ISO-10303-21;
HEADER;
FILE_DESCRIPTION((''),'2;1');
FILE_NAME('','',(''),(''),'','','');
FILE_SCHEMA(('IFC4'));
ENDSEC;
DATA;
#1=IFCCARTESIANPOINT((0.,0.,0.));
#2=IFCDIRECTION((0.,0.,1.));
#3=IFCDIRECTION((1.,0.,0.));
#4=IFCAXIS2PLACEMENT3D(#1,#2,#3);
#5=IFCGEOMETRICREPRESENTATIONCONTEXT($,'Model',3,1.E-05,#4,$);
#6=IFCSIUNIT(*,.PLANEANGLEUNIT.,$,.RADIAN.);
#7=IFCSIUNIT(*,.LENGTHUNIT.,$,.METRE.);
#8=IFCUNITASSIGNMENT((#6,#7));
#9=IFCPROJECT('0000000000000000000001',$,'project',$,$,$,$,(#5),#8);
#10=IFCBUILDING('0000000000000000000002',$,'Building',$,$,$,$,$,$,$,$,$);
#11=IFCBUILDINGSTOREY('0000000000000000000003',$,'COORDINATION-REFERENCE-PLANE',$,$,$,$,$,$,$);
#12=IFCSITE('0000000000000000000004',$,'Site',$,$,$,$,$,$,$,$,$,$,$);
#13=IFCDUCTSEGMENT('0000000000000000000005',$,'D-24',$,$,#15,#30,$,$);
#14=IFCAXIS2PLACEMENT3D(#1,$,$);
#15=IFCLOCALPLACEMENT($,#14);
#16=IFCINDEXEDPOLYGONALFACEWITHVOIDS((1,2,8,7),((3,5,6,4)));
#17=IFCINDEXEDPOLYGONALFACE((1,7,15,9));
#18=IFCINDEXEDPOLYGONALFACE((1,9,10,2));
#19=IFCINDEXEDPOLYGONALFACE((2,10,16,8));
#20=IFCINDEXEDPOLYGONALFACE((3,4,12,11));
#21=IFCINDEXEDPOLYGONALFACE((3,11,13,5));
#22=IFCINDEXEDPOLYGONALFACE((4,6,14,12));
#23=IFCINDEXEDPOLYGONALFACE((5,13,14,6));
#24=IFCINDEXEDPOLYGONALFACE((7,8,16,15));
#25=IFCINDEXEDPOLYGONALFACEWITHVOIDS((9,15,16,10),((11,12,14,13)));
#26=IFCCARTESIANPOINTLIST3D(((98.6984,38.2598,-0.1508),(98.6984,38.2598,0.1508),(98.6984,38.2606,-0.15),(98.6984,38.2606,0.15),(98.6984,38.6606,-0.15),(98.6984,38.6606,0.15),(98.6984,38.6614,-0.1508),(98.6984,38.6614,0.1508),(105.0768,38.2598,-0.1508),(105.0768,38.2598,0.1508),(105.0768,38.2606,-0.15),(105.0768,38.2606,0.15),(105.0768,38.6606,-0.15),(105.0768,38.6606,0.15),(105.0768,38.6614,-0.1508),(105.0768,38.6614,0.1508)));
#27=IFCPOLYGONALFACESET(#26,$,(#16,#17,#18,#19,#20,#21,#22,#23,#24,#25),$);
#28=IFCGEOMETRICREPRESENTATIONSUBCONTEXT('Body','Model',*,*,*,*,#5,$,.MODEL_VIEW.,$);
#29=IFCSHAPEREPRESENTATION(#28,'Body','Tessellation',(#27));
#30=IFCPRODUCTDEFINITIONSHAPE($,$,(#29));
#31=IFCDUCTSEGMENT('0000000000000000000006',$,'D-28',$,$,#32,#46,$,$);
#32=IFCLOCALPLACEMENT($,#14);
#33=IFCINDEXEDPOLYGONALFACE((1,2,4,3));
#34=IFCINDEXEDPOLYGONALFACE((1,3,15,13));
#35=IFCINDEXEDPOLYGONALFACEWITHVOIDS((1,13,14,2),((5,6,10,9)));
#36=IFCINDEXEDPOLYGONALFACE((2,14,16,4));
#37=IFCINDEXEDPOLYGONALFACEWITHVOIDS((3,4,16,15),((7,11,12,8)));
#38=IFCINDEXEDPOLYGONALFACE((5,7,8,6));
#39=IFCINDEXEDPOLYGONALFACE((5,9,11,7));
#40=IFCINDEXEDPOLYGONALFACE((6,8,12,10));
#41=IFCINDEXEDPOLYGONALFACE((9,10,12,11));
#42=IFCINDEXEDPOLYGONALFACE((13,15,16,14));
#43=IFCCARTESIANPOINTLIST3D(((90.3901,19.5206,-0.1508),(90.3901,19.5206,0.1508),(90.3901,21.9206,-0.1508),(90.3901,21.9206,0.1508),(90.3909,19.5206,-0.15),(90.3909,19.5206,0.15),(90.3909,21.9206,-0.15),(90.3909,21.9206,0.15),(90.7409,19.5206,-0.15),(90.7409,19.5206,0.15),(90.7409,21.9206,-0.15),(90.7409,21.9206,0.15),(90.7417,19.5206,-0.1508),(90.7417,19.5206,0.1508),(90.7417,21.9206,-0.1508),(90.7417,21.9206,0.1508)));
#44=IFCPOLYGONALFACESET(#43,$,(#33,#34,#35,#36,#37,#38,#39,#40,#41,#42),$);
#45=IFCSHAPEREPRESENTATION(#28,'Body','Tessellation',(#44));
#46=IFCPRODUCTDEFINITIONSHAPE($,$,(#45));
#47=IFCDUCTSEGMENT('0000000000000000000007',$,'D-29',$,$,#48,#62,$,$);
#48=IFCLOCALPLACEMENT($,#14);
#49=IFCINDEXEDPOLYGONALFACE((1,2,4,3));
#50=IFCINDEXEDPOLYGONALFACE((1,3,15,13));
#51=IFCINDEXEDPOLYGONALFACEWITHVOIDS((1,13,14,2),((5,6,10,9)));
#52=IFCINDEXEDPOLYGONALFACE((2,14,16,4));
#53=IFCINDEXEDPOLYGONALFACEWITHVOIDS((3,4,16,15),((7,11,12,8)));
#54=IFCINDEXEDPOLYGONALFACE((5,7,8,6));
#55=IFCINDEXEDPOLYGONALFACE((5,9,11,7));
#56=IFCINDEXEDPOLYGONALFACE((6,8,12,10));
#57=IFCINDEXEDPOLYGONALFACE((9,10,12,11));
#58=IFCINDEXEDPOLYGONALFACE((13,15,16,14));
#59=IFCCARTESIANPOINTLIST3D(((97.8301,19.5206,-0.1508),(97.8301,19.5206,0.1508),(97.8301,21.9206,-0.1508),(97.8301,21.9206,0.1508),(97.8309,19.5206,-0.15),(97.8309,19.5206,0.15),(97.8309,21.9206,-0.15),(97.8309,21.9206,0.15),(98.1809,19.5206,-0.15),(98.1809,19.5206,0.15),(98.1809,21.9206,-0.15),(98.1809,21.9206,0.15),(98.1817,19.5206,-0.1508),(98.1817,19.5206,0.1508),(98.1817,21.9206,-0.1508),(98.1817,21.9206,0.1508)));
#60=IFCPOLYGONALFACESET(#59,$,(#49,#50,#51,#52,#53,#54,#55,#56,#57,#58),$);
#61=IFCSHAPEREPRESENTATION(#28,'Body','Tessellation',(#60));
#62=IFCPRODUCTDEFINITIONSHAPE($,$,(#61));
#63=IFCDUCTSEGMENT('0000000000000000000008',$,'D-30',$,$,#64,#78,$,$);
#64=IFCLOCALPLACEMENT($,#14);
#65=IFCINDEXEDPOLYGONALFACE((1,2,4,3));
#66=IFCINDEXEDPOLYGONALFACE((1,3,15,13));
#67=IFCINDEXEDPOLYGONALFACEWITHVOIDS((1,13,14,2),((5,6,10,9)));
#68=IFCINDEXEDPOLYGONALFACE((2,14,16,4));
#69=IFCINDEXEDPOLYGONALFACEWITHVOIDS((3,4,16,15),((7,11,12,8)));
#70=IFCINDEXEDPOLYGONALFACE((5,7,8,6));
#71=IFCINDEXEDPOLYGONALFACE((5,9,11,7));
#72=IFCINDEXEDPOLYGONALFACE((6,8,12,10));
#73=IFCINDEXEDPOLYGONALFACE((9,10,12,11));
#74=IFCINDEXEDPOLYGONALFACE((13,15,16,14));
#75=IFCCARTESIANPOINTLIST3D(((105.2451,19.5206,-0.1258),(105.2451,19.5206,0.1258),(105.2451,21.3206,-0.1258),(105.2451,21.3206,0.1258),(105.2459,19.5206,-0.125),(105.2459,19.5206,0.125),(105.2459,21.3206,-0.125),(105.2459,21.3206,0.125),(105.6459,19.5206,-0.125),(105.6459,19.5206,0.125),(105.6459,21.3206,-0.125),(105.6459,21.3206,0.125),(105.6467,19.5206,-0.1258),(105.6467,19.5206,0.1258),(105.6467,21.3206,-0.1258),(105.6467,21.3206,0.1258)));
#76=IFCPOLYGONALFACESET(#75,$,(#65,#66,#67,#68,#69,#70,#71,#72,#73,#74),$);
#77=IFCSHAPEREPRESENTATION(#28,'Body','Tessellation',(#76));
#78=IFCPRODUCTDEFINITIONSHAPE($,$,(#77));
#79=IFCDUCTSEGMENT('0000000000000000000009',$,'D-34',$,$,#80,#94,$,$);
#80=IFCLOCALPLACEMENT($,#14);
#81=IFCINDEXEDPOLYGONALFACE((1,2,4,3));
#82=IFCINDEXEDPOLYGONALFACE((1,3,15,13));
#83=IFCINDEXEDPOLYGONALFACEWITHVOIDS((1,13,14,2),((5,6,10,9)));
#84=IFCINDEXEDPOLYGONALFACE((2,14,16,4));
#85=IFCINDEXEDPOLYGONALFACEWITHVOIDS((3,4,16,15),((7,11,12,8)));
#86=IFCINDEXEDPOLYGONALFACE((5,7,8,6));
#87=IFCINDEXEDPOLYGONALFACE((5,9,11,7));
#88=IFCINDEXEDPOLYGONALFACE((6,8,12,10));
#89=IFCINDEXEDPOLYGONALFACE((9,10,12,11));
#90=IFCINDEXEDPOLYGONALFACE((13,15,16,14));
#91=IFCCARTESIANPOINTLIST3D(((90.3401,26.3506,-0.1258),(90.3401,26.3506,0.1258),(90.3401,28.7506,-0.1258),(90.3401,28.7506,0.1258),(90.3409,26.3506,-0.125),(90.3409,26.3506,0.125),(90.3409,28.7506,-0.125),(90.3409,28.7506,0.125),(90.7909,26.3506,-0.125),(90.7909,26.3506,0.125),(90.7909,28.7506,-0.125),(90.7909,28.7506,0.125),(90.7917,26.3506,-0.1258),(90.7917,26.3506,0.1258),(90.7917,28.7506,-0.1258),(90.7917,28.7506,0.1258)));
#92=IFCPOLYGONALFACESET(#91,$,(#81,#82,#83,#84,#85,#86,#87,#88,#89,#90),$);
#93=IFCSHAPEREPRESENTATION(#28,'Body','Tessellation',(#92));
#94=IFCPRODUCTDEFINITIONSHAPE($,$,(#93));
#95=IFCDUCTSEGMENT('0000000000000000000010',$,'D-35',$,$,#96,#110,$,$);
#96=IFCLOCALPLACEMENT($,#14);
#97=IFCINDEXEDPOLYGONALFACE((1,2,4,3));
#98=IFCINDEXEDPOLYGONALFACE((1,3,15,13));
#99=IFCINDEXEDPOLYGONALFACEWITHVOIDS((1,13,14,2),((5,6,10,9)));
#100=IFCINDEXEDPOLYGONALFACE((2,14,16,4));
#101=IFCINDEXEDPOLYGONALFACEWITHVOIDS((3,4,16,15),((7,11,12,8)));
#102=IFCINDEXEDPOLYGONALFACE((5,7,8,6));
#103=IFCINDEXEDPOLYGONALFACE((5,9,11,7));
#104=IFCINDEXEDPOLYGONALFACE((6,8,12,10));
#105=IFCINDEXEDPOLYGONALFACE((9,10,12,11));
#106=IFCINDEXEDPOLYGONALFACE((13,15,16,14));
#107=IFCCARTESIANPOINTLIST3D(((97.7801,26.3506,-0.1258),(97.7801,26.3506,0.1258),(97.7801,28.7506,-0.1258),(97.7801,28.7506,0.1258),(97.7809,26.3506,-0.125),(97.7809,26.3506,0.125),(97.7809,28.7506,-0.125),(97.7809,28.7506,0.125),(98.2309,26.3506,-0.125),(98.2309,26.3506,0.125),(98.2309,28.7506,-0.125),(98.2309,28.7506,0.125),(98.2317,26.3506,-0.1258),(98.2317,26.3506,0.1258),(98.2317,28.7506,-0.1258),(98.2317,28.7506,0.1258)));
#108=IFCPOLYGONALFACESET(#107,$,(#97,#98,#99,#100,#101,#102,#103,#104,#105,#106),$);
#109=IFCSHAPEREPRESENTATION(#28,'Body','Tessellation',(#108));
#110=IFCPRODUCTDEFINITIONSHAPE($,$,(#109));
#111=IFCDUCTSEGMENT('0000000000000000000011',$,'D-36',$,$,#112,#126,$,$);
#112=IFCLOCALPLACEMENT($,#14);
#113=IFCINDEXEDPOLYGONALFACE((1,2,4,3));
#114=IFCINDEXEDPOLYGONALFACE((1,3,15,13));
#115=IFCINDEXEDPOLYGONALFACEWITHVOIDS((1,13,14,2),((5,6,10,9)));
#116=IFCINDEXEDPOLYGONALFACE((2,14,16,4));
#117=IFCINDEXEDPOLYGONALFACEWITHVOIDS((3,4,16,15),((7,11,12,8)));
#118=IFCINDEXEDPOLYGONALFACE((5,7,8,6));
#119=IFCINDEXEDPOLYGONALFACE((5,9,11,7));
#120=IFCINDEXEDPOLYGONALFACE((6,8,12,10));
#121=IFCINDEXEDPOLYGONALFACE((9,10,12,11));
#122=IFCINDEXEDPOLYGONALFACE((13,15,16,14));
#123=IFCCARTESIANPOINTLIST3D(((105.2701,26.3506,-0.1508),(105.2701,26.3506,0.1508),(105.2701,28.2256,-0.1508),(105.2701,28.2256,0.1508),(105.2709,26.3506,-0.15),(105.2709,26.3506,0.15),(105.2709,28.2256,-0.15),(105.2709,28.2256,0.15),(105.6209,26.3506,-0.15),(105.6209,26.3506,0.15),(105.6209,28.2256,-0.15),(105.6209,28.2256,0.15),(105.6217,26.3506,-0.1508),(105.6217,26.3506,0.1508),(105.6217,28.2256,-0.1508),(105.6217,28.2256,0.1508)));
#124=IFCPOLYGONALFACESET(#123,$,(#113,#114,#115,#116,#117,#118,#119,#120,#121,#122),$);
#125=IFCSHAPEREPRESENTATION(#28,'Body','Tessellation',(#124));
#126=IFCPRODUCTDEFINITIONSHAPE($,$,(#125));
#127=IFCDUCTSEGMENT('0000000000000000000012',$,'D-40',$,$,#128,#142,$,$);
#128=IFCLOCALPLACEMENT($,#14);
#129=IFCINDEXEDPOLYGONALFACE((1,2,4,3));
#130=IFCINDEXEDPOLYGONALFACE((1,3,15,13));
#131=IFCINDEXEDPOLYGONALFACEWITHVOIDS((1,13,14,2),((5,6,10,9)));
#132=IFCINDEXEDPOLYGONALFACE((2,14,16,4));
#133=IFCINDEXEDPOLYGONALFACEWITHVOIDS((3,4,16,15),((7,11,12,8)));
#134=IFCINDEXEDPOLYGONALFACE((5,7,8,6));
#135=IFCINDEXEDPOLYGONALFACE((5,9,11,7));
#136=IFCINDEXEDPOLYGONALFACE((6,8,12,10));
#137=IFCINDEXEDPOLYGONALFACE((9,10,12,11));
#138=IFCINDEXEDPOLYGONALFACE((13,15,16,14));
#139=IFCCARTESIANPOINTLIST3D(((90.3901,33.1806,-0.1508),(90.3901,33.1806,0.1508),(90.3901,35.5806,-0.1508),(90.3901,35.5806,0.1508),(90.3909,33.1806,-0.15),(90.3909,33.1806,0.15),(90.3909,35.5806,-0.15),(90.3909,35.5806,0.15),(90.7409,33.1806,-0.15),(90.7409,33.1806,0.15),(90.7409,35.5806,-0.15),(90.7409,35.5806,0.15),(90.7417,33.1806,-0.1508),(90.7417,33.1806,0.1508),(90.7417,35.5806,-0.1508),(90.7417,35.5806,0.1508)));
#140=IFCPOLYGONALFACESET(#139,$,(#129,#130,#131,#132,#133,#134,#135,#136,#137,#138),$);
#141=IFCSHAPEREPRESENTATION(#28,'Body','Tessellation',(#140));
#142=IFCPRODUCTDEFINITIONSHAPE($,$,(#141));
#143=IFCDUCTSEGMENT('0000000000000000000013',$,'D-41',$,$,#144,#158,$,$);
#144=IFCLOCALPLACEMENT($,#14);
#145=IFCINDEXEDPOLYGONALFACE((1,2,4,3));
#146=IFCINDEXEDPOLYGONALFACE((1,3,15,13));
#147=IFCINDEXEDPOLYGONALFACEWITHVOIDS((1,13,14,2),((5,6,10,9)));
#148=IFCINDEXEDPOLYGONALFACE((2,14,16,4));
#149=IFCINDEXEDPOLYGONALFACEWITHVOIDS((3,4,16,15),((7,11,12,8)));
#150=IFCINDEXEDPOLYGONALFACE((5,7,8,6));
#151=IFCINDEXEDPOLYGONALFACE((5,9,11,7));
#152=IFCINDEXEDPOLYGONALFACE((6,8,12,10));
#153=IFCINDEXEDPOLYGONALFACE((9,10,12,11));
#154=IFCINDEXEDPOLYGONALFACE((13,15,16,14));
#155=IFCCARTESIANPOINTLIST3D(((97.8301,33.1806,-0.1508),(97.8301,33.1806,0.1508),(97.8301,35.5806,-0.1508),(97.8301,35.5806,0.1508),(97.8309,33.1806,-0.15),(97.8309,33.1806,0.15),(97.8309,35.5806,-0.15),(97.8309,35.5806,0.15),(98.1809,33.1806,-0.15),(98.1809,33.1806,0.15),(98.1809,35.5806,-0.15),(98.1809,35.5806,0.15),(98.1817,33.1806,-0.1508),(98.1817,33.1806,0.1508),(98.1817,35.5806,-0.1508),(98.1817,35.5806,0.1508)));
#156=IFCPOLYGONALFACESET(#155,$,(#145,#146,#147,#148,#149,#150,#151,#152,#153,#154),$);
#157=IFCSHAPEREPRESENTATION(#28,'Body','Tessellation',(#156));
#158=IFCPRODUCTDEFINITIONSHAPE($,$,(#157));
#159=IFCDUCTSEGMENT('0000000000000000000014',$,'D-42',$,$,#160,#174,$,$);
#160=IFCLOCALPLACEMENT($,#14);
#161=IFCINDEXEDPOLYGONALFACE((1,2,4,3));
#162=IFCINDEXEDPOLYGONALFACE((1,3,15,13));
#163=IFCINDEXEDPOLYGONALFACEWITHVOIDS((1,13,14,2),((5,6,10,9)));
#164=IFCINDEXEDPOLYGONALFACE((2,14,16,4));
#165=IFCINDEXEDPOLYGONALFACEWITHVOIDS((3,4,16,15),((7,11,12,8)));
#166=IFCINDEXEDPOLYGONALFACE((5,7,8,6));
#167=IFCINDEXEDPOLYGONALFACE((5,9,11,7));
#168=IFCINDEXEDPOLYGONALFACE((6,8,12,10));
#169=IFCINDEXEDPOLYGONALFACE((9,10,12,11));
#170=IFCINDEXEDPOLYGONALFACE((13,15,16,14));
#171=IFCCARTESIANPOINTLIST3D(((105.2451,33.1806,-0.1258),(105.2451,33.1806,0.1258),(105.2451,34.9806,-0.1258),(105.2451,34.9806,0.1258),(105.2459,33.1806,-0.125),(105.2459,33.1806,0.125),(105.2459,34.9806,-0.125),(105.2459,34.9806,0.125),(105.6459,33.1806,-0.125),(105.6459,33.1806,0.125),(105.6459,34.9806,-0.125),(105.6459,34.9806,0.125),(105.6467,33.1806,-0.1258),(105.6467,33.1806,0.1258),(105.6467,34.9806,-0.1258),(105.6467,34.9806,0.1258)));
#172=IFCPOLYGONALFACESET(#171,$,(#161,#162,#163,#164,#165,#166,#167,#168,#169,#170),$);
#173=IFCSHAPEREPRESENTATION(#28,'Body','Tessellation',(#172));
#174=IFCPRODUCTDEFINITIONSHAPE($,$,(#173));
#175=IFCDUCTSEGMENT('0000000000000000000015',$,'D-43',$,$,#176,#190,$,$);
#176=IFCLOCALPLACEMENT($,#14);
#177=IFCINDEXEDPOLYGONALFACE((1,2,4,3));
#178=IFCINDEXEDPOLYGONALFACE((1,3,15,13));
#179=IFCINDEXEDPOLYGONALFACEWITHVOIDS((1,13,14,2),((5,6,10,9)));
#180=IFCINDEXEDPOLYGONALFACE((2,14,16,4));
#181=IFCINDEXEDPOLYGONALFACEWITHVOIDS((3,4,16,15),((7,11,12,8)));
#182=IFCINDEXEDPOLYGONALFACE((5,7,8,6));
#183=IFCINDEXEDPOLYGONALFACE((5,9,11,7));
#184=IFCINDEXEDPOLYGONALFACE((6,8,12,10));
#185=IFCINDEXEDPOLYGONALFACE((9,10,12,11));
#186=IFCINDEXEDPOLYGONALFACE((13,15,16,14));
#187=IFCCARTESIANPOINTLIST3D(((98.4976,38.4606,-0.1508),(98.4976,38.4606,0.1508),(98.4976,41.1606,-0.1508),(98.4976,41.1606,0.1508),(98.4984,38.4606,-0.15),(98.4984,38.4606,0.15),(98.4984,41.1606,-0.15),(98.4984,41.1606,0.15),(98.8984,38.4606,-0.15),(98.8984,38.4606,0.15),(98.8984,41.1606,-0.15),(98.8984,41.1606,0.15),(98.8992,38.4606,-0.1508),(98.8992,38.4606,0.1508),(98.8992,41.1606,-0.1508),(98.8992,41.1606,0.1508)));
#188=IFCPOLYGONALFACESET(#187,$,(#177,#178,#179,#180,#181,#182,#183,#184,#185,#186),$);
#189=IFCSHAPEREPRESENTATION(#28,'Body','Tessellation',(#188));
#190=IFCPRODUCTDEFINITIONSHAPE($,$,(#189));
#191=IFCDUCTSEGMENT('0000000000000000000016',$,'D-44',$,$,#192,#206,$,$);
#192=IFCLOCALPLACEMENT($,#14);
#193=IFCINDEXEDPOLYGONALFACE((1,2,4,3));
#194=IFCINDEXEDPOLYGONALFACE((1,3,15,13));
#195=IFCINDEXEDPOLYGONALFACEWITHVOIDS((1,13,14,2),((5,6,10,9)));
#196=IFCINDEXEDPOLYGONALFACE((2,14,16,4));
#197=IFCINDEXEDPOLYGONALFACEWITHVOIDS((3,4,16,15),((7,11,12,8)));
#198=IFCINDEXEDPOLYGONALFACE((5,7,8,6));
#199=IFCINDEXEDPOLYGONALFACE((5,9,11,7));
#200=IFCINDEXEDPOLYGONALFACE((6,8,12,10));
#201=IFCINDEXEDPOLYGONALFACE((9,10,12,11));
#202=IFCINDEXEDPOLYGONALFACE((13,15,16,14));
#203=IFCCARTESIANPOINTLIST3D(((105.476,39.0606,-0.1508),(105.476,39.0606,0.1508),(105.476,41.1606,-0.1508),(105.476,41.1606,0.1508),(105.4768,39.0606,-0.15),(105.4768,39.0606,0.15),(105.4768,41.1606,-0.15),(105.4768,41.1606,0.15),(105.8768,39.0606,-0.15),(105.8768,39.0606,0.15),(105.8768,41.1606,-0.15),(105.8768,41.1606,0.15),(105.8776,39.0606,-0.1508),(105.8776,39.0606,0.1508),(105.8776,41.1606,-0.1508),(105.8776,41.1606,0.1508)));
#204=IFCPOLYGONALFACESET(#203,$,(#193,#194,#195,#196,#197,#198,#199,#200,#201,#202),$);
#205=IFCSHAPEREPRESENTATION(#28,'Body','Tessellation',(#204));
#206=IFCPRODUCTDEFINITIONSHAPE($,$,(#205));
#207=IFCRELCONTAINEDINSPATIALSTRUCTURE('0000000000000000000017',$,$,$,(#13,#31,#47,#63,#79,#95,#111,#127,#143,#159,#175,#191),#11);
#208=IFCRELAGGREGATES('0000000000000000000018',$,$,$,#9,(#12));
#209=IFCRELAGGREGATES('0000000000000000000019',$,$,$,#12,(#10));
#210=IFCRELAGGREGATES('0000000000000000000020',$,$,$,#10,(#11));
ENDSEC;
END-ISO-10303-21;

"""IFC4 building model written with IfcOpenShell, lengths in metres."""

from ifc_helpers import new_model, si_unit, frame, origin, origin_with_axes, place, context, subcontext, project, spatial, hollow_rectangle, extrude, element, save


model = new_model("IFC4")

# Units and contexts
model_context = context("Model", 3, precision=1e-05, world=origin_with_axes())
body_context = subcontext(model_context, "Body", "Model", "MODEL_VIEW")
ifc_project = project(units=[si_unit("PLANEANGLEUNIT", "RADIAN"), si_unit("LENGTHUNIT", "METRE")], contexts=[model_context])

# Site, building, storey
site = spatial("IfcSite", under=ifc_project, Name="Site")
building = spatial("IfcBuilding", under=site, Name="Building")
storey = spatial("IfcBuildingStorey", under=building, Name="COORDINATION-REFERENCE-PLANE")

# Duct segments
duct_segment_1_placement = place(None, frame((98.6984, 38.4606, 0.0), z_axis=(1.0, 0.0, 0.0), x_axis=(0.0, 1.0, 0.0)))
element("IfcDuctSegment", 1, at=duct_segment_1_placement, inside=storey, Name="D-24", context=body_context, shape_type="SweptSolid", body=[
    extrude(hollow_rectangle(XDim=0.4016, YDim=0.3016, WallThickness=0.0008), origin(), (0.0, 0.0, 1.0), 6.3783),
])
for number, where, z_axis, x_axis, name in (
    (2, (90.5659, 19.5206, 0.0), (0.0, 1.0, 0.0), (1.0, 0.0, 0.0), "D-28"),
    (3, (98.0059, 19.5206, 0.0), (0.0, 1.0, 0.0), (1.0, 0.0, 0.0), "D-29"),
):
    element("IfcDuctSegment", number, at=place(None, frame(where, z_axis=z_axis, x_axis=x_axis)), inside=storey, Name=name, context=body_context, shape_type="SweptSolid", body=[
        extrude(hollow_rectangle(XDim=0.3516, YDim=0.3016, WallThickness=0.0008), origin(), (0.0, 0.0, 1.0), 2.4),
    ])
duct_segment_2_placement = place(None, frame((105.4459, 19.5206, 0.0), z_axis=(0.0, 1.0, 0.0), x_axis=(1.0, 0.0, 0.0)))
element("IfcDuctSegment", 4, at=duct_segment_2_placement, inside=storey, Name="D-30", context=body_context, shape_type="SweptSolid", body=[
    extrude(hollow_rectangle(XDim=0.4016, YDim=0.2516, WallThickness=0.0008), origin(), (0.0, 0.0, 1.0), 1.8),
])
for number, where, z_axis, x_axis, name in (
    (5, (90.5659, 26.3506, 0.0), (0.0, 1.0, 0.0), (1.0, 0.0, 0.0), "D-34"),
    (6, (98.0059, 26.3506, 0.0), (0.0, 1.0, 0.0), (1.0, 0.0, 0.0), "D-35"),
):
    element("IfcDuctSegment", number, at=place(None, frame(where, z_axis=z_axis, x_axis=x_axis)), inside=storey, Name=name, context=body_context, shape_type="SweptSolid", body=[
        extrude(hollow_rectangle(XDim=0.4516, YDim=0.2516, WallThickness=0.0008), origin(), (0.0, 0.0, 1.0), 2.4),
    ])
duct_segment_3_placement = place(None, frame((105.4459, 26.3506, 0.0), z_axis=(0.0, 1.0, 0.0), x_axis=(1.0, 0.0, 0.0)))
element("IfcDuctSegment", 7, at=duct_segment_3_placement, inside=storey, Name="D-36", context=body_context, shape_type="SweptSolid", body=[
    extrude(hollow_rectangle(XDim=0.3516, YDim=0.3016, WallThickness=0.0008), origin(), (0.0, 0.0, 1.0), 1.875),
])
for number, where, z_axis, x_axis, name in (
    (8, (90.5659, 33.1806, 0.0), (0.0, 1.0, 0.0), (1.0, 0.0, 0.0), "D-40"),
    (9, (98.0059, 33.1806, 0.0), (0.0, 1.0, 0.0), (1.0, 0.0, 0.0), "D-41"),
):
    element("IfcDuctSegment", number, at=place(None, frame(where, z_axis=z_axis, x_axis=x_axis)), inside=storey, Name=name, context=body_context, shape_type="SweptSolid", body=[
        extrude(hollow_rectangle(XDim=0.3516, YDim=0.3016, WallThickness=0.0008), origin(), (0.0, 0.0, 1.0), 2.4),
    ])
duct_segment_4_placement = place(None, frame((105.4459, 33.1806, 0.0), z_axis=(0.0, 1.0, 0.0), x_axis=(1.0, 0.0, 0.0)))
element("IfcDuctSegment", 10, at=duct_segment_4_placement, inside=storey, Name="D-42", context=body_context, shape_type="SweptSolid", body=[
    extrude(hollow_rectangle(XDim=0.4016, YDim=0.2516, WallThickness=0.0008), origin(), (0.0, 0.0, 1.0), 1.8),
])
duct_segment_5_placement = place(None, frame((98.6984, 38.4606, 0.0), z_axis=(0.0, 1.0, 0.0), x_axis=(1.0, 0.0, 0.0)))
element("IfcDuctSegment", 11, at=duct_segment_5_placement, inside=storey, Name="D-43", context=body_context, shape_type="SweptSolid", body=[
    extrude(hollow_rectangle(XDim=0.4016, YDim=0.3016, WallThickness=0.0008), origin(), (0.0, 0.0, 1.0), 2.7),
])
duct_segment_6_placement = place(None, frame((105.6768, 39.0606, 0.0), z_axis=(0.0, 1.0, 0.0), x_axis=(1.0, 0.0, 0.0)))
element("IfcDuctSegment", 12, at=duct_segment_6_placement, inside=storey, Name="D-44", context=body_context, shape_type="SweptSolid", body=[
    extrude(hollow_rectangle(XDim=0.4016, YDim=0.3016, WallThickness=0.0008), origin(), (0.0, 0.0, 1.0), 2.1),
])

save(model, "model.ifc")
